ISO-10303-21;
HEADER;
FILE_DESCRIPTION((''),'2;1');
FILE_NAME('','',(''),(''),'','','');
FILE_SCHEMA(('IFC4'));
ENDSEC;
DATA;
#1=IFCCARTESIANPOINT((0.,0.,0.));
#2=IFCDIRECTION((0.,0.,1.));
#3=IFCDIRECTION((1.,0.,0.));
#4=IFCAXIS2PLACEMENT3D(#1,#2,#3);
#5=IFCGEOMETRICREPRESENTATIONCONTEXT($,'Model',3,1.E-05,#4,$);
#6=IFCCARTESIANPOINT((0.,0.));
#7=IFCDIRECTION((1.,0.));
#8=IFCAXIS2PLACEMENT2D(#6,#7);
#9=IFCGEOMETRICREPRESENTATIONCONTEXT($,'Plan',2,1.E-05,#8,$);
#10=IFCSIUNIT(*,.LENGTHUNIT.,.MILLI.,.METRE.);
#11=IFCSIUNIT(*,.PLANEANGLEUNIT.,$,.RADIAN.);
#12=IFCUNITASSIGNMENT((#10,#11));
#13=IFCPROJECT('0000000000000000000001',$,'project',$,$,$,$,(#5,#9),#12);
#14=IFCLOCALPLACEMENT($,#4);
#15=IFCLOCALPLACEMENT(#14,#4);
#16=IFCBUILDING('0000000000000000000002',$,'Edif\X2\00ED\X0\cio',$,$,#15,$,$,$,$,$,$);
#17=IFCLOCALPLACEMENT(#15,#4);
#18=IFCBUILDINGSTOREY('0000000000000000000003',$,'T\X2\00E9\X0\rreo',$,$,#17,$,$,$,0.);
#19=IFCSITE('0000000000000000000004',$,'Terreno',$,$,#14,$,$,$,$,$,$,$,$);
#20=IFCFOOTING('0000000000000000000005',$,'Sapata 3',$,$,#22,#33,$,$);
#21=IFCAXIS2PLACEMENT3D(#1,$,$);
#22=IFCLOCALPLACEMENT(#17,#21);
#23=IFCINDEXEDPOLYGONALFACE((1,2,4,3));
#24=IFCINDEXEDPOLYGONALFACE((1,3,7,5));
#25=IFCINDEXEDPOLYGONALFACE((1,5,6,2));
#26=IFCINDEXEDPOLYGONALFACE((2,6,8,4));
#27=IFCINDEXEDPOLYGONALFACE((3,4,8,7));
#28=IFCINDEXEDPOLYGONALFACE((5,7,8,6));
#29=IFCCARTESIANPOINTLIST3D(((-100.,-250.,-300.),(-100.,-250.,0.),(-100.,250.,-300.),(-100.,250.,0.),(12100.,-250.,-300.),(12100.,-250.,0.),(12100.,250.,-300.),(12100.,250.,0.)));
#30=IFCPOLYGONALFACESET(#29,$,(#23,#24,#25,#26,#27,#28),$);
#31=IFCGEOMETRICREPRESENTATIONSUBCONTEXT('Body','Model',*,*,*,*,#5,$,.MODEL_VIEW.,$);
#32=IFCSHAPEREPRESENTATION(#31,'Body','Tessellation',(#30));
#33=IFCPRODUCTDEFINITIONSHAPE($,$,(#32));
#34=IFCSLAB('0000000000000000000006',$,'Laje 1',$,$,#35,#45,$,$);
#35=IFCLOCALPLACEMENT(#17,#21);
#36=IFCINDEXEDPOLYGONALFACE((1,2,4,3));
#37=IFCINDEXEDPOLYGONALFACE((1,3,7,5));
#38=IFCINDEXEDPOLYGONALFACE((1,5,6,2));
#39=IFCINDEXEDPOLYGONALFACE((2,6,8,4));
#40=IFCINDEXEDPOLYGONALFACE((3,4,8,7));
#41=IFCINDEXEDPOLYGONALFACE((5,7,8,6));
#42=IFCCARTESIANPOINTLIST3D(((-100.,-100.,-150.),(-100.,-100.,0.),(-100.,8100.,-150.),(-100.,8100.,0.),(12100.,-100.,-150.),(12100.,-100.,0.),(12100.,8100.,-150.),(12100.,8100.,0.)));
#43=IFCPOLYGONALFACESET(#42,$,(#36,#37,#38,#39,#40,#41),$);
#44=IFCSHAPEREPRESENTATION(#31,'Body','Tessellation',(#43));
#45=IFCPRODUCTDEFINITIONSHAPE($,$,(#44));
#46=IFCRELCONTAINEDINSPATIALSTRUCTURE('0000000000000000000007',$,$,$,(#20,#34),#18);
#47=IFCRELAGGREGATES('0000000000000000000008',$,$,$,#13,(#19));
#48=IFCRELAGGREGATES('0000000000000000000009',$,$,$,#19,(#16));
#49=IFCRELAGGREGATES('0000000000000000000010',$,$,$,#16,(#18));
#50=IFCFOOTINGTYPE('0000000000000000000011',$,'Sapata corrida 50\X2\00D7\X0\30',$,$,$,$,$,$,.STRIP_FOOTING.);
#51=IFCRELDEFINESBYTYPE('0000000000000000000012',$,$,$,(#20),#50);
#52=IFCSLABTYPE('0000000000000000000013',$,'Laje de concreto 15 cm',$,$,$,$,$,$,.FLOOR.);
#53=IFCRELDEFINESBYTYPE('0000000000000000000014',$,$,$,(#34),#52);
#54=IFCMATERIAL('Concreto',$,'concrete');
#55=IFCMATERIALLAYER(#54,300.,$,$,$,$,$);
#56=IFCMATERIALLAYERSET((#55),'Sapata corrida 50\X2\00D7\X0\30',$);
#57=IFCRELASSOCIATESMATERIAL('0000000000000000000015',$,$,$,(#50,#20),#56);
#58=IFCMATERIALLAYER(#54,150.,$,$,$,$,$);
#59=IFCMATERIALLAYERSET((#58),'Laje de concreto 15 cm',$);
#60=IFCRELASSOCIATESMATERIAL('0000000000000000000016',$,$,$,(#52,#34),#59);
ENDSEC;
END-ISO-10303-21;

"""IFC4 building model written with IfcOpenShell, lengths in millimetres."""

from ifc_helpers import new_model, si_unit, frame, origin_with_axes, origin_2d_with_axis, place, context, subcontext, project, spatial, indexed_curve, outline, extrude, material, layer, layer_set, layer_usage, type_object, element, save


model = new_model("IFC4")

# Units and contexts
model_context = context("Model", 3, precision=1e-05, world=origin_with_axes())
plan_context = context("Plan", 2, precision=1e-05, world=origin_2d_with_axis())
body_context = subcontext(model_context, "Body", "Model", "MODEL_VIEW")
ifc_project = project(units=[si_unit("LENGTHUNIT", "METRE", prefix="MILLI"), si_unit("PLANEANGLEUNIT", "RADIAN")], contexts=[model_context, plan_context])

# Site, building, storey
site_placement = place(None, origin_with_axes())
site = spatial("IfcSite", under=ifc_project, at=site_placement, Name="Terreno")
building_placement = place(site_placement, origin_with_axes())
building = spatial("IfcBuilding", under=site, at=building_placement, Name="Edifício")
storey_placement = place(building_placement, origin_with_axes())
storey = spatial("IfcBuildingStorey", under=building, at=storey_placement, Name="Térreo", Elevation=0.0)

# Footing
ifc_material_1 = material(Name="Concreto", Category="concrete")
ifc_layer_1 = layer(ifc_material_1, 300.0)
ifc_layer_set_1 = layer_set([ifc_layer_1], Name="Sapata corrida 50×30")
ifc_layer_usage_1 = layer_usage(ifc_layer_set_1, "AXIS3", "POSITIVE", 0.0)
footing_type = type_object("IfcFootingType", Name="Sapata corrida 50×30", PredefinedType="STRIP_FOOTING", material=ifc_layer_set_1)
footing_placement = place(storey_placement, frame((-100.0, -250.0, -300.0), z_axis=(0.0, 0.0, 1.0), x_axis=(1.0, 0.0, 0.0)))
element("IfcFooting", 1, at=footing_placement, inside=storey, type_object=footing_type, material=ifc_layer_usage_1, Name="Sapata 3", context=body_context, shape_type="SweptSolid", body=[
    extrude(outline(indexed_curve([(0.0, 0.0), (12200.0, 0.0), (12200.0, 500.0), (0.0, 500.0)])), None, (0.0, 0.0, 1.0), 300.0),
])

# Slab
ifc_layer_2 = layer(ifc_material_1, 150.0)
ifc_layer_set_2 = layer_set([ifc_layer_2], Name="Laje de concreto 15 cm")
ifc_layer_usage_2 = layer_usage(ifc_layer_set_2, "AXIS3", "POSITIVE", 0.0)
slab_type = type_object("IfcSlabType", Name="Laje de concreto 15 cm", PredefinedType="FLOOR", material=ifc_layer_set_2)
slab_placement = place(storey_placement, frame((-100.0, -100.0, -150.0), z_axis=(0.0, 0.0, 1.0), x_axis=(1.0, 0.0, 0.0)))
element("IfcSlab", 2, at=slab_placement, inside=storey, type_object=slab_type, material=ifc_layer_usage_2, Name="Laje 1", context=body_context, shape_type="SweptSolid", body=[
    extrude(outline(indexed_curve([(0.0, 0.0), (12200.0, 0.0), (12200.0, 8200.0), (0.0, 8200.0), (0.0, 0.0)], self_intersect=False)), origin_with_axes(), (0.0, 0.0, 1.0), 150.0),
])

save(model, "model.ifc")
